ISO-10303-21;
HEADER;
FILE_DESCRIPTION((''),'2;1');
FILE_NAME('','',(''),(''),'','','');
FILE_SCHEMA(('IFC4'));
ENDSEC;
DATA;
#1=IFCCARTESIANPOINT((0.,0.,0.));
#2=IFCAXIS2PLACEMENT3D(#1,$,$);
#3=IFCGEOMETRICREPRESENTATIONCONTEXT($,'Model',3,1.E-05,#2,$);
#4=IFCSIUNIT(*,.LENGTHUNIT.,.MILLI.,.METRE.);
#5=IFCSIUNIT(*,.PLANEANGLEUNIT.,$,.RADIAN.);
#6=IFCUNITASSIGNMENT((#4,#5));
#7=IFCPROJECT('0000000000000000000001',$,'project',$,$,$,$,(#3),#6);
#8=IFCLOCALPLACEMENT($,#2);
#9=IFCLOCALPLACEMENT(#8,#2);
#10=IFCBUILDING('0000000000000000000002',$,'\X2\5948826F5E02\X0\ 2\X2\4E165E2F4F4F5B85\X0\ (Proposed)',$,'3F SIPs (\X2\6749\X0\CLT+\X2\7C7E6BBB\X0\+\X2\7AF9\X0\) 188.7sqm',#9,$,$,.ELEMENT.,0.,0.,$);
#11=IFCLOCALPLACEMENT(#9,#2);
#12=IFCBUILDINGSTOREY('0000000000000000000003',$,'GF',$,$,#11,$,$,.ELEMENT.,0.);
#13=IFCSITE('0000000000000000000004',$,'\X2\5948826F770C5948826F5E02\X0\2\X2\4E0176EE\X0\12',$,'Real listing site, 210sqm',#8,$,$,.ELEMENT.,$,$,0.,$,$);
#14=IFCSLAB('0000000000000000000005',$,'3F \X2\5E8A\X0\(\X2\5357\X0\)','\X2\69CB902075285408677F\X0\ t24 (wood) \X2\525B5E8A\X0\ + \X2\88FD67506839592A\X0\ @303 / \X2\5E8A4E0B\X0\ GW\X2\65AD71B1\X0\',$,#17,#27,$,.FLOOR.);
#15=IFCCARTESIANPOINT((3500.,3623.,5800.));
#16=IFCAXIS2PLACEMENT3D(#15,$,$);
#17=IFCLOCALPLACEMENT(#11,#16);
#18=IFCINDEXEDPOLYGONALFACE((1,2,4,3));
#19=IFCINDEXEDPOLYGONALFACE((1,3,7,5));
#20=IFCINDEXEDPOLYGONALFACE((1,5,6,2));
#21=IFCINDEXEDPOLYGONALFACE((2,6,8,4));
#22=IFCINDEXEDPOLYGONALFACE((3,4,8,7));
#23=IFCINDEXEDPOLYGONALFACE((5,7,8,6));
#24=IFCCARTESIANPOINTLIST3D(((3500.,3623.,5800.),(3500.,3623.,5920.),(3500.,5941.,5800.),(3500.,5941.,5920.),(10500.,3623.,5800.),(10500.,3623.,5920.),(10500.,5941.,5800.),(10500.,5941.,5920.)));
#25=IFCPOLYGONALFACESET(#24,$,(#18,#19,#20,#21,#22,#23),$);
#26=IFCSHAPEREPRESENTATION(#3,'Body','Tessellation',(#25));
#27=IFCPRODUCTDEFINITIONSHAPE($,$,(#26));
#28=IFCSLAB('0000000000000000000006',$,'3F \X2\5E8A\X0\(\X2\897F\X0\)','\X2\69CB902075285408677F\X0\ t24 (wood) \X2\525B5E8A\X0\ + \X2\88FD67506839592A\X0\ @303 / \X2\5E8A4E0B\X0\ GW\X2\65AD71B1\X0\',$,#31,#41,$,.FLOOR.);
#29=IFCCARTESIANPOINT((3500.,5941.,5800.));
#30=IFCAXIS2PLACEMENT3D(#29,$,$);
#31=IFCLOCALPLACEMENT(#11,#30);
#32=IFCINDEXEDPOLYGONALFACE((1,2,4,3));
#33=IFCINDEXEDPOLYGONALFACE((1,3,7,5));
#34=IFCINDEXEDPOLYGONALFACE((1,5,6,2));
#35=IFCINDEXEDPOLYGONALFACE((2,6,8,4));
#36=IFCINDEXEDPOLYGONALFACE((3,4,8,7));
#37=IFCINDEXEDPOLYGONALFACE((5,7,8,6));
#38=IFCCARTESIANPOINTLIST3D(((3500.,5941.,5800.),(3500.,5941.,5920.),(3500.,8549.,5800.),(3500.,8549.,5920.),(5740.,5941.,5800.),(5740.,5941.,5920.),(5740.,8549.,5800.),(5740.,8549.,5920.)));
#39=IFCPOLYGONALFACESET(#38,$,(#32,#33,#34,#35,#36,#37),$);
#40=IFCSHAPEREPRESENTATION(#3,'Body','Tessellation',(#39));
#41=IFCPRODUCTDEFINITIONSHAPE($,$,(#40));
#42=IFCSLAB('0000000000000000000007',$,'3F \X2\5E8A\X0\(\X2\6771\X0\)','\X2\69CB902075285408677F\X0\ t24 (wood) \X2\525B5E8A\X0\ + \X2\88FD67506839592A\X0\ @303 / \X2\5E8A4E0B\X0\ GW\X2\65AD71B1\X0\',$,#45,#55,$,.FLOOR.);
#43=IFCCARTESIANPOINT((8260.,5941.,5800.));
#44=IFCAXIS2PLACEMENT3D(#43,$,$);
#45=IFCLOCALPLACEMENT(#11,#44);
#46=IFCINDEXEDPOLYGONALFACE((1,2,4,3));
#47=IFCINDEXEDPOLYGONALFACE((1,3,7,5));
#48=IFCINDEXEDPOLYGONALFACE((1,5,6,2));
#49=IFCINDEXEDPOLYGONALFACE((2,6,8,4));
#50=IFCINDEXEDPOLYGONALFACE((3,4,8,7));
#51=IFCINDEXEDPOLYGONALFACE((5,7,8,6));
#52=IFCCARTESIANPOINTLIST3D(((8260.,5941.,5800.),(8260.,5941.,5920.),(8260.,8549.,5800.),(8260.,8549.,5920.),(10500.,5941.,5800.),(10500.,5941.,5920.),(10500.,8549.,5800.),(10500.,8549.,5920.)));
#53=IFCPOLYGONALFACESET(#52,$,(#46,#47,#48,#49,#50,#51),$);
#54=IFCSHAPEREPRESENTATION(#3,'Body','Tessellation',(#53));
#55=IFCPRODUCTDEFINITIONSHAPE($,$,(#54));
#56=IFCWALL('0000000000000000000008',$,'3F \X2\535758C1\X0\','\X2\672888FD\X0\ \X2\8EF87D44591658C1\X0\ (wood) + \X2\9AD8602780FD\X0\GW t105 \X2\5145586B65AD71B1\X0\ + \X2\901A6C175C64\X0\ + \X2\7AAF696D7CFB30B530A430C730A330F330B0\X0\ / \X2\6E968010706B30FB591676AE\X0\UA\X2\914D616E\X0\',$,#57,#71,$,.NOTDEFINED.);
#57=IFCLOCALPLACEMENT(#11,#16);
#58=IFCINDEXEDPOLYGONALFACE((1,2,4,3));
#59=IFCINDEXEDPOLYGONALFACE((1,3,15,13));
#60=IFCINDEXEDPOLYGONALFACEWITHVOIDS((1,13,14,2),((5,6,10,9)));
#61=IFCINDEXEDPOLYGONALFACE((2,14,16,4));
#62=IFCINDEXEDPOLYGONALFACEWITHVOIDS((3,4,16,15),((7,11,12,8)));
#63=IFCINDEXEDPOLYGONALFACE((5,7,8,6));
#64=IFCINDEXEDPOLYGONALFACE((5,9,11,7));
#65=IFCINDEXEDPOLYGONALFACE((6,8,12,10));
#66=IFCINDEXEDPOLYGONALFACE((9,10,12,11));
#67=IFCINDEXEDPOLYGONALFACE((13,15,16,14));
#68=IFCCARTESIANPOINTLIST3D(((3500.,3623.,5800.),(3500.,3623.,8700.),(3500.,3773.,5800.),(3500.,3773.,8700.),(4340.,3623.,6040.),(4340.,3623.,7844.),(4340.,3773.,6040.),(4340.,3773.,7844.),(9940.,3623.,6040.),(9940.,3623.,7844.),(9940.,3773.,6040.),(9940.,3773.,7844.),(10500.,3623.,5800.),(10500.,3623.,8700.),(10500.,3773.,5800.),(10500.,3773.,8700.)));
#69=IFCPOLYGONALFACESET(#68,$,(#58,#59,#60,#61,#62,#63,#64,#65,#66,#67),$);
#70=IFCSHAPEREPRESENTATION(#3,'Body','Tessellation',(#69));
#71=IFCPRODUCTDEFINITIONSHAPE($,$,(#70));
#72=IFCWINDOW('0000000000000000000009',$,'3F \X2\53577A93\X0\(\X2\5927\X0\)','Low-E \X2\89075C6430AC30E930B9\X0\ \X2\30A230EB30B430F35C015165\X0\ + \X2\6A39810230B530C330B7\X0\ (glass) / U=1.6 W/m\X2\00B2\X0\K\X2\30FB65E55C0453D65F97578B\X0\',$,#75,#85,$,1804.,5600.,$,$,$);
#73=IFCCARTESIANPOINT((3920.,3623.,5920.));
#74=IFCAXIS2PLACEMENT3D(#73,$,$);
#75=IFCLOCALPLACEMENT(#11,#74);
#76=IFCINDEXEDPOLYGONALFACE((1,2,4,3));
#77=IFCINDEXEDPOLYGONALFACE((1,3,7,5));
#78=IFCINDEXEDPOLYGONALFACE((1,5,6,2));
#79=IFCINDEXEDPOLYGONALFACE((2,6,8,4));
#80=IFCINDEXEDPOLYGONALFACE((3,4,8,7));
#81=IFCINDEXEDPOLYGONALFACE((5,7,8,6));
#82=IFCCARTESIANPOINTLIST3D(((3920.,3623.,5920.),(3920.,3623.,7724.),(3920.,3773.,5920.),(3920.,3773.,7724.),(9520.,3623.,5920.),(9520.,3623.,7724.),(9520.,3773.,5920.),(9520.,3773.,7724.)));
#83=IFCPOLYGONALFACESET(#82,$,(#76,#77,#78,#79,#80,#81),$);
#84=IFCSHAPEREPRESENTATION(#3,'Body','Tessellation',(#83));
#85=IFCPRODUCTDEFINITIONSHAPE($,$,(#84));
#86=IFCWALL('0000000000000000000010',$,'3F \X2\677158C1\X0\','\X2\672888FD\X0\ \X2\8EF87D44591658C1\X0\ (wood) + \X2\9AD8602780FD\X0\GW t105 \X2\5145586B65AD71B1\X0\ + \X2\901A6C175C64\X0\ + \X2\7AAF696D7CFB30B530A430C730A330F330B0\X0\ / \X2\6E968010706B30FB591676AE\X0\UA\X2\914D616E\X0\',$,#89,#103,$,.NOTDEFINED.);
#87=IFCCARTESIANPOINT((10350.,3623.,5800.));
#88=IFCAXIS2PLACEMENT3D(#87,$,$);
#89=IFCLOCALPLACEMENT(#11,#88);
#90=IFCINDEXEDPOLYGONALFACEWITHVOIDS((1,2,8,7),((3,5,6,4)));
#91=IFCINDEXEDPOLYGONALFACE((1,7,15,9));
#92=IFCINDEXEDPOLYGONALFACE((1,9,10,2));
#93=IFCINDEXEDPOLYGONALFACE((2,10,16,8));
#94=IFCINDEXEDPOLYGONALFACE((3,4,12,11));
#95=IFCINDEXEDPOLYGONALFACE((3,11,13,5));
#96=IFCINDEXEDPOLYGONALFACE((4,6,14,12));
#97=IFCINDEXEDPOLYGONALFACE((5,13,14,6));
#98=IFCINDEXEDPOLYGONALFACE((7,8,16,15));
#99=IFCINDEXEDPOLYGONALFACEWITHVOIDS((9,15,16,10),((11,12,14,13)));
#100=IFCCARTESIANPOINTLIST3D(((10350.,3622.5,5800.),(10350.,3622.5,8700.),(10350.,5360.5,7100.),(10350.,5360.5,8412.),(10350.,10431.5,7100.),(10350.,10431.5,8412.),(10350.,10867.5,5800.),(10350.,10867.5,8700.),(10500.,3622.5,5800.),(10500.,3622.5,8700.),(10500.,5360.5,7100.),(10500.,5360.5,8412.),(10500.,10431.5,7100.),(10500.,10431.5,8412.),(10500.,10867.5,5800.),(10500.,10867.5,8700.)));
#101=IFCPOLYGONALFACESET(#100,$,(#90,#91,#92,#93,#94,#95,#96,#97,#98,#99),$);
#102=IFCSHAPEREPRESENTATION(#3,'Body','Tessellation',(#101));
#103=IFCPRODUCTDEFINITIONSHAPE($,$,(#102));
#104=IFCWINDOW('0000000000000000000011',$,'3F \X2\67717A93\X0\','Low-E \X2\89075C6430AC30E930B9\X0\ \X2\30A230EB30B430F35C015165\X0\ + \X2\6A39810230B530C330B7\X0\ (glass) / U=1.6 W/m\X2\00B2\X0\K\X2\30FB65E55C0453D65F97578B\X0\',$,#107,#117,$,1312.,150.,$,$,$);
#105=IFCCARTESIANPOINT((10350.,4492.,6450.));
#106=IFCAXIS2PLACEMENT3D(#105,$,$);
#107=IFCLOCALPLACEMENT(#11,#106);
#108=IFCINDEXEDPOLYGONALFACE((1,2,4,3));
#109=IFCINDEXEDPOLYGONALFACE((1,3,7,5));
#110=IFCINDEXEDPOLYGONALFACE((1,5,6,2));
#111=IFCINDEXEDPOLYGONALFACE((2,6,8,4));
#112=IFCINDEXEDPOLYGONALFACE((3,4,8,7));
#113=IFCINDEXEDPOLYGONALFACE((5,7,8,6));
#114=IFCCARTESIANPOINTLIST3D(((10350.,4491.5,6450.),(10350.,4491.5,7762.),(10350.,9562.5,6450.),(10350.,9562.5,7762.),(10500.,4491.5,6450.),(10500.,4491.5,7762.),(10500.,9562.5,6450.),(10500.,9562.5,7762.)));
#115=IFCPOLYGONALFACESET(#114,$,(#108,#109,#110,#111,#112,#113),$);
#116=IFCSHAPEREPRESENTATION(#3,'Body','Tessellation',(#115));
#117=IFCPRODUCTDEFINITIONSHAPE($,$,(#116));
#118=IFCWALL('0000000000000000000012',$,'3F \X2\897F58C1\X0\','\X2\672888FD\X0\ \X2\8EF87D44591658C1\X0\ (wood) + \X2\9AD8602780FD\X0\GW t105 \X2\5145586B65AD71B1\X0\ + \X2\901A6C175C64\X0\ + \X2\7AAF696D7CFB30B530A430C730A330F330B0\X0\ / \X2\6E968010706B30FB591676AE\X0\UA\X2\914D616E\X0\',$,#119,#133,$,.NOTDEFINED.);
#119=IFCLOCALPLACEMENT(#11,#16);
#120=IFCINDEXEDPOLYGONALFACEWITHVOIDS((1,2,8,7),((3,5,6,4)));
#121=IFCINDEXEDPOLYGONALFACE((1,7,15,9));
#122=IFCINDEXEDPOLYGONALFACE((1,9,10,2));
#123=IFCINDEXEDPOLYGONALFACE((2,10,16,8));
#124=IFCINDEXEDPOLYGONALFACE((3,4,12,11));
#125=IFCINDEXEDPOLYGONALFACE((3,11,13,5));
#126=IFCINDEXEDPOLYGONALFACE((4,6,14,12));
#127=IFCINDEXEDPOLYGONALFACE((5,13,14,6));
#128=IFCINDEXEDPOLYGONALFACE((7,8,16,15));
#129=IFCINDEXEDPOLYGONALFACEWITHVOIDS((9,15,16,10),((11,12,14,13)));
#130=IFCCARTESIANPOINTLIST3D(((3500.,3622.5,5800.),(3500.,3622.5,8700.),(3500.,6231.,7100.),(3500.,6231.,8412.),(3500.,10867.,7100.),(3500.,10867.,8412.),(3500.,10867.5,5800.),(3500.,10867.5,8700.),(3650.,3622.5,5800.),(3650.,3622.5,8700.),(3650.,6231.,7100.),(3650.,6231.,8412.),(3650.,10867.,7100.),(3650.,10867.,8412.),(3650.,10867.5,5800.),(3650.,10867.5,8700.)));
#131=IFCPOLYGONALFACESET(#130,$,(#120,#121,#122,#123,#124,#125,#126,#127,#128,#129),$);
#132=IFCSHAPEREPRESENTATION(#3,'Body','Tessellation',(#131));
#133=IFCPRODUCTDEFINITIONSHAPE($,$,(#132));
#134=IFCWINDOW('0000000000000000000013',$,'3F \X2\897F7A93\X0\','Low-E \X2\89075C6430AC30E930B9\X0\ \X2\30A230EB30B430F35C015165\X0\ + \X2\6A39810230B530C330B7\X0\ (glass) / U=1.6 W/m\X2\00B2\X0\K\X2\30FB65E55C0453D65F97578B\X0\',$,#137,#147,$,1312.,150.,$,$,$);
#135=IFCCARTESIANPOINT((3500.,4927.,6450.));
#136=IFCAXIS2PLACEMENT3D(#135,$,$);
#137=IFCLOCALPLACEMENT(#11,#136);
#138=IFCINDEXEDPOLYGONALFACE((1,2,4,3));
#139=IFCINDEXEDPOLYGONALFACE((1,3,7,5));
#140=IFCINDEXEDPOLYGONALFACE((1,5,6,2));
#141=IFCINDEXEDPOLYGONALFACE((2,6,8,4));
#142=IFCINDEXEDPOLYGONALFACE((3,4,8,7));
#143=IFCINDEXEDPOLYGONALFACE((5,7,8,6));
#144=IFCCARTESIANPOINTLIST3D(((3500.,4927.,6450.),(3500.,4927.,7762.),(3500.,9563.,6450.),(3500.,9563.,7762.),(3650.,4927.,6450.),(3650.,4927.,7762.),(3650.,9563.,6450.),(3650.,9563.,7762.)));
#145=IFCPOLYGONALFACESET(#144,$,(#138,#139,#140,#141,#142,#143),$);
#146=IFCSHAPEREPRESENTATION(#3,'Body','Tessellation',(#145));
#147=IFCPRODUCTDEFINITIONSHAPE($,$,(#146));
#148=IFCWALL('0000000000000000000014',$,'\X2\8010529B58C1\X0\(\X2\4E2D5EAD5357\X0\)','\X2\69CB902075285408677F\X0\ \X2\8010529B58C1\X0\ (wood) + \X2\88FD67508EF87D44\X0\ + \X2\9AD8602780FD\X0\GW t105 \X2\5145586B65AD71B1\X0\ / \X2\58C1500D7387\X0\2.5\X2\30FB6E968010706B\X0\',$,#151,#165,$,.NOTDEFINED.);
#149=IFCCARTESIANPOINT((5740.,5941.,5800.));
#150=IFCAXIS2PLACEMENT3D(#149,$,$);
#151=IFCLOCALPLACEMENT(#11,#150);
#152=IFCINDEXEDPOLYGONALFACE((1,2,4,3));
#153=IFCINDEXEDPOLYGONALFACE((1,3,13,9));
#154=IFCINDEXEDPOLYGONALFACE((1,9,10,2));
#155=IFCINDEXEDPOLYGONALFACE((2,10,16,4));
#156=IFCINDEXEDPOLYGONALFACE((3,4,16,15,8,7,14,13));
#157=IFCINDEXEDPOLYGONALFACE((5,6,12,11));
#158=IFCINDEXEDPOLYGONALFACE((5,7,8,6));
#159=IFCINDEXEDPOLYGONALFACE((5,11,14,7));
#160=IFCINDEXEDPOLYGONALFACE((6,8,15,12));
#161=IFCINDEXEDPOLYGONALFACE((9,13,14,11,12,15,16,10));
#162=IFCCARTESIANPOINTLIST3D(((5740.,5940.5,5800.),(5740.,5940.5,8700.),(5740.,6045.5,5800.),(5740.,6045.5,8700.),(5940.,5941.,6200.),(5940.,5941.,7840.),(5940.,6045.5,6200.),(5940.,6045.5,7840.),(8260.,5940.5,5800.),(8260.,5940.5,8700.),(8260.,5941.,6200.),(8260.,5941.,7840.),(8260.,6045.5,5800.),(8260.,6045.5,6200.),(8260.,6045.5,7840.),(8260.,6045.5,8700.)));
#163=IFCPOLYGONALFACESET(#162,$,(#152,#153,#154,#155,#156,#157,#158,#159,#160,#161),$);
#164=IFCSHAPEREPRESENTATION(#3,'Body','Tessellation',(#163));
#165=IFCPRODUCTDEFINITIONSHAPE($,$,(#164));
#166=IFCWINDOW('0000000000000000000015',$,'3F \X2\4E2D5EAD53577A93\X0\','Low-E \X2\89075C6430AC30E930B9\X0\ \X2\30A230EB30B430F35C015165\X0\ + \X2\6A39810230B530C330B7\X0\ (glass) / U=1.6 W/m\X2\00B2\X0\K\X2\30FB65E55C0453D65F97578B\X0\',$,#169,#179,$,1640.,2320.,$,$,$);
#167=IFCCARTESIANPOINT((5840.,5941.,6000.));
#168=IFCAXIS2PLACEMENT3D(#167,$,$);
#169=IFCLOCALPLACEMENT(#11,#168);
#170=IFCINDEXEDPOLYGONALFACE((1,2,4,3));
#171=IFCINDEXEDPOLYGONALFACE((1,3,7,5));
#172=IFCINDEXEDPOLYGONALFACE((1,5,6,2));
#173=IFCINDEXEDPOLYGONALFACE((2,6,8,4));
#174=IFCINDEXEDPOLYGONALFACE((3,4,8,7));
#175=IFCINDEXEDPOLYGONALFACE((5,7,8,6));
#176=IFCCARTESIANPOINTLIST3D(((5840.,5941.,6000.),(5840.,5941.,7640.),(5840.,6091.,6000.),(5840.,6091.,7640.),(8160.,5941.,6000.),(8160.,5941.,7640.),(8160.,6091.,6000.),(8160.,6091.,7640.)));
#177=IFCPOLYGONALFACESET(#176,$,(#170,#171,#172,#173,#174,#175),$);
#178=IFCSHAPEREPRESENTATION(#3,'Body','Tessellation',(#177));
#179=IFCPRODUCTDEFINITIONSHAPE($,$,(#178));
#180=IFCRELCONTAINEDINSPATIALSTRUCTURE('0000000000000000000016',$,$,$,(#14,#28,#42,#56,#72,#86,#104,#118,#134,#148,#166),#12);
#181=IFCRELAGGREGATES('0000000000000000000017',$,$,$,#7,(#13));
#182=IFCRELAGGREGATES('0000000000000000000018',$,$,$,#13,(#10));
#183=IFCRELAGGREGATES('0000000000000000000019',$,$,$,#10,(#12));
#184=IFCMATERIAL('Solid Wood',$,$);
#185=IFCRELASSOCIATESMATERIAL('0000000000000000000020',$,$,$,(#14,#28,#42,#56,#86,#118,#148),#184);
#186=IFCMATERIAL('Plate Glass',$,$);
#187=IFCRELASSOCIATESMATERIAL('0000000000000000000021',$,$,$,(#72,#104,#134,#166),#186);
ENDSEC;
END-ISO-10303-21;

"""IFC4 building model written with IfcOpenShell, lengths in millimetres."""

from ifc_helpers import new_model, si_unit, frame, frame_2d, origin, place, context, project, spatial, rectangle, extrude, material, element, fill, save


model = new_model("IFC4")

# Units and contexts
model_context = context("Model", 3, precision=1e-05, world=origin())
ifc_project = project(units=[si_unit("LENGTHUNIT", "METRE", prefix="MILLI"), si_unit("PLANEANGLEUNIT", "RADIAN")], contexts=[model_context])

# Site, building, storey
site_placement = place(None, origin())
site = spatial("IfcSite", under=ifc_project, at=site_placement, Name="奈良県奈良市2丁目12", ObjectType="Real listing site, 210sqm", CompositionType="ELEMENT", RefElevation=0.0)
building_placement = place(site_placement, origin())
building = spatial("IfcBuilding", under=site, at=building_placement, Name="奈良市 2世帯住宅 (Proposed)", ObjectType="3F SIPs (杉CLT+籾殻+竹) 188.7sqm", CompositionType="ELEMENT", ElevationOfRefHeight=0.0, ElevationOfTerrain=0.0)
storey_placement = place(building_placement, origin())
storey = spatial("IfcBuildingStorey", under=building, at=storey_placement, Name="GF", CompositionType="ELEMENT", Elevation=0.0)

# Slabs
ifc_material_1 = material(Name="Solid Wood")
slab_1_placement = place(storey_placement, frame((3500.0, 3623.0, 5800.0)))
element("IfcSlab", 1, at=slab_1_placement, inside=storey, material=ifc_material_1, Name="3F 床(南)", Description="構造用合板 t24 (wood) 剛床 + 製材根太 @303 / 床下 GW断熱", PredefinedType="FLOOR", context=model_context, shape_type="SweptSolid", body=[
    extrude(rectangle(XDim=7000.0, YDim=2318.0, at=frame_2d((3500.0, 1159.0))), frame((3500.0, 3623.0, 5800.0)), (0.0, 0.0, 1.0), 120.0),
])
slab_2_placement = place(storey_placement, frame((3500.0, 5941.0, 5800.0)))
element("IfcSlab", 2, at=slab_2_placement, inside=storey, material=ifc_material_1, Name="3F 床(西)", Description="構造用合板 t24 (wood) 剛床 + 製材根太 @303 / 床下 GW断熱", PredefinedType="FLOOR", context=model_context, shape_type="SweptSolid", body=[
    extrude(rectangle(XDim=2240.0, YDim=2608.0, at=frame_2d((1120.0, 1304.0))), frame((3500.0, 5941.0, 5800.0)), (0.0, 0.0, 1.0), 120.0),
])
slab_3_placement = place(storey_placement, frame((8260.0, 5941.0, 5800.0)))
element("IfcSlab", 3, at=slab_3_placement, inside=storey, material=ifc_material_1, Name="3F 床(東)", Description="構造用合板 t24 (wood) 剛床 + 製材根太 @303 / 床下 GW断熱", PredefinedType="FLOOR", context=model_context, shape_type="SweptSolid", body=[
    extrude(rectangle(XDim=2240.0, YDim=2608.0, at=frame_2d((1120.0, 1304.0))), frame((8260.0, 5941.0, 5800.0)), (0.0, 0.0, 1.0), 120.0),
])

# Walls, openings, windows
wall_1_placement = place(storey_placement, frame((3500.0, 3623.0, 5800.0)))
wall_1 = element("IfcWall", 4, at=wall_1_placement, inside=storey, material=ifc_material_1, Name="3F 南壁", Description="木製 軸組外壁 (wood) + 高性能GW t105 充填断熱 + 通気層 + 窯業系サイディング / 準耐火・外皮UA配慮", PredefinedType="NOTDEFINED", context=model_context, shape_type="SweptSolid", body=[
    extrude(rectangle(XDim=7000.0, YDim=150.0, at=frame_2d((3500.0, 75.0))), frame((3500.0, 3623.0, 5800.0)), (0.0, 0.0, 1.0), 2900.0),
])
opening_1_placement = place(storey_placement, frame((3920.0, 3623.0, 5920.0)))
opening_1 = element("IfcOpeningElement", 5, at=opening_1_placement, cuts=wall_1, PredefinedType="NOTDEFINED", context=model_context, shape_type="SweptSolid", body=[
    extrude(rectangle(XDim=5600.0, YDim=150.0, at=frame_2d((2800.0, 75.0))), frame((3920.0, 3623.0, 5920.0)), (0.0, 0.0, 1.0), 1804.0),
])
ifc_material_2 = material(Name="Plate Glass")
window_1_placement = place(storey_placement, frame((3920.0, 3623.0, 5920.0)))
window_1 = element("IfcWindow", 6, at=window_1_placement, inside=storey, material=ifc_material_2, Name="3F 南窓(大)", Description="Low-E 複層ガラス アルゴン封入 + 樹脂サッシ (glass) / U=1.6 W/m²K・日射取得型", OverallHeight=1804.0, OverallWidth=5600.0, context=model_context, shape_type="SweptSolid", body=[
    extrude(rectangle(XDim=5600.0, YDim=150.0, at=frame_2d((2800.0, 75.0))), frame((3920.0, 3623.0, 5920.0)), (0.0, 0.0, 1.0), 1804.0),
])
fill(opening_1, window_1)
wall_2_placement = place(storey_placement, frame((10350.0, 3623.0, 5800.0)))
wall_2 = element("IfcWall", 7, at=wall_2_placement, inside=storey, material=ifc_material_1, Name="3F 東壁", Description="木製 軸組外壁 (wood) + 高性能GW t105 充填断熱 + 通気層 + 窯業系サイディング / 準耐火・外皮UA配慮", PredefinedType="NOTDEFINED", context=model_context, shape_type="SweptSolid", body=[
    extrude(rectangle(XDim=150.0, YDim=7245.0, at=frame_2d((75.0, 3622.0))), frame((10350.0, 3623.0, 5800.0)), (0.0, 0.0, 1.0), 2900.0),
])
opening_2_placement = place(storey_placement, frame((10350.0, 4492.0, 6450.0)))
opening_2 = element("IfcOpeningElement", 8, at=opening_2_placement, cuts=wall_2, PredefinedType="NOTDEFINED", context=model_context, shape_type="SweptSolid", body=[
    extrude(rectangle(XDim=150.0, YDim=5071.0, at=frame_2d((75.0, 2535.0))), frame((10350.0, 4492.0, 6450.0)), (0.0, 0.0, 1.0), 1312.0),
])
window_2_placement = place(storey_placement, frame((10350.0, 4492.0, 6450.0)))
window_2 = element("IfcWindow", 9, at=window_2_placement, inside=storey, material=ifc_material_2, Name="3F 東窓", Description="Low-E 複層ガラス アルゴン封入 + 樹脂サッシ (glass) / U=1.6 W/m²K・日射取得型", OverallHeight=1312.0, OverallWidth=150.0, context=model_context, shape_type="SweptSolid", body=[
    extrude(rectangle(XDim=150.0, YDim=5071.0, at=frame_2d((75.0, 2535.0))), frame((10350.0, 4492.0, 6450.0)), (0.0, 0.0, 1.0), 1312.0),
])
fill(opening_2, window_2)
wall_3_placement = place(storey_placement, frame((3500.0, 3623.0, 5800.0)))
wall_3 = element("IfcWall", 10, at=wall_3_placement, inside=storey, material=ifc_material_1, Name="3F 西壁", Description="木製 軸組外壁 (wood) + 高性能GW t105 充填断熱 + 通気層 + 窯業系サイディング / 準耐火・外皮UA配慮", PredefinedType="NOTDEFINED", context=model_context, shape_type="SweptSolid", body=[
    extrude(rectangle(XDim=150.0, YDim=7245.0, at=frame_2d((75.0, 3622.0))), frame((3500.0, 3623.0, 5800.0)), (0.0, 0.0, 1.0), 2900.0),
])
opening_3_placement = place(storey_placement, frame((3500.0, 4927.0, 6450.0)))
opening_3 = element("IfcOpeningElement", 11, at=opening_3_placement, cuts=wall_3, PredefinedType="NOTDEFINED", context=model_context, shape_type="SweptSolid", body=[
    extrude(rectangle(XDim=150.0, YDim=4636.0, at=frame_2d((75.0, 2318.0))), frame((3500.0, 4927.0, 6450.0)), (0.0, 0.0, 1.0), 1312.0),
])
window_3_placement = place(storey_placement, frame((3500.0, 4927.0, 6450.0)))
window_3 = element("IfcWindow", 12, at=window_3_placement, inside=storey, material=ifc_material_2, Name="3F 西窓", Description="Low-E 複層ガラス アルゴン封入 + 樹脂サッシ (glass) / U=1.6 W/m²K・日射取得型", OverallHeight=1312.0, OverallWidth=150.0, context=model_context, shape_type="SweptSolid", body=[
    extrude(rectangle(XDim=150.0, YDim=4636.0, at=frame_2d((75.0, 2318.0))), frame((3500.0, 4927.0, 6450.0)), (0.0, 0.0, 1.0), 1312.0),
])
fill(opening_3, window_3)
wall_4_placement = place(storey_placement, frame((5740.0, 5941.0, 5800.0)))
wall_4 = element("IfcWall", 13, at=wall_4_placement, inside=storey, material=ifc_material_1, Name="耐力壁(中庭南)", Description="構造用合板 耐力壁 (wood) + 製材軸組 + 高性能GW t105 充填断熱 / 壁倍率2.5・準耐火", PredefinedType="NOTDEFINED", context=model_context, shape_type="SweptSolid", body=[
    extrude(rectangle(XDim=2520.0, YDim=105.0, at=frame_2d((1260.0, 52.0))), frame((5740.0, 5941.0, 5800.0)), (0.0, 0.0, 1.0), 2900.0),
])
opening_4_placement = place(storey_placement, frame((5840.0, 5941.0, 6000.0)))
opening_4 = element("IfcOpeningElement", 14, at=opening_4_placement, cuts=wall_4, PredefinedType="NOTDEFINED", context=model_context, shape_type="SweptSolid", body=[
    extrude(rectangle(XDim=2320.0, YDim=150.0, at=frame_2d((1160.0, 75.0))), frame((5840.0, 5941.0, 6000.0)), (0.0, 0.0, 1.0), 1640.0),
])
window_4_placement = place(storey_placement, frame((5840.0, 5941.0, 6000.0)))
window_4 = element("IfcWindow", 15, at=window_4_placement, inside=storey, material=ifc_material_2, Name="3F 中庭南窓", Description="Low-E 複層ガラス アルゴン封入 + 樹脂サッシ (glass) / U=1.6 W/m²K・日射取得型", OverallHeight=1640.0, OverallWidth=2320.0, context=model_context, shape_type="SweptSolid", body=[
    extrude(rectangle(XDim=2320.0, YDim=150.0, at=frame_2d((1160.0, 75.0))), frame((5840.0, 5941.0, 6000.0)), (0.0, 0.0, 1.0), 1640.0),
])
fill(opening_4, window_4)

save(model, "model.ifc")
